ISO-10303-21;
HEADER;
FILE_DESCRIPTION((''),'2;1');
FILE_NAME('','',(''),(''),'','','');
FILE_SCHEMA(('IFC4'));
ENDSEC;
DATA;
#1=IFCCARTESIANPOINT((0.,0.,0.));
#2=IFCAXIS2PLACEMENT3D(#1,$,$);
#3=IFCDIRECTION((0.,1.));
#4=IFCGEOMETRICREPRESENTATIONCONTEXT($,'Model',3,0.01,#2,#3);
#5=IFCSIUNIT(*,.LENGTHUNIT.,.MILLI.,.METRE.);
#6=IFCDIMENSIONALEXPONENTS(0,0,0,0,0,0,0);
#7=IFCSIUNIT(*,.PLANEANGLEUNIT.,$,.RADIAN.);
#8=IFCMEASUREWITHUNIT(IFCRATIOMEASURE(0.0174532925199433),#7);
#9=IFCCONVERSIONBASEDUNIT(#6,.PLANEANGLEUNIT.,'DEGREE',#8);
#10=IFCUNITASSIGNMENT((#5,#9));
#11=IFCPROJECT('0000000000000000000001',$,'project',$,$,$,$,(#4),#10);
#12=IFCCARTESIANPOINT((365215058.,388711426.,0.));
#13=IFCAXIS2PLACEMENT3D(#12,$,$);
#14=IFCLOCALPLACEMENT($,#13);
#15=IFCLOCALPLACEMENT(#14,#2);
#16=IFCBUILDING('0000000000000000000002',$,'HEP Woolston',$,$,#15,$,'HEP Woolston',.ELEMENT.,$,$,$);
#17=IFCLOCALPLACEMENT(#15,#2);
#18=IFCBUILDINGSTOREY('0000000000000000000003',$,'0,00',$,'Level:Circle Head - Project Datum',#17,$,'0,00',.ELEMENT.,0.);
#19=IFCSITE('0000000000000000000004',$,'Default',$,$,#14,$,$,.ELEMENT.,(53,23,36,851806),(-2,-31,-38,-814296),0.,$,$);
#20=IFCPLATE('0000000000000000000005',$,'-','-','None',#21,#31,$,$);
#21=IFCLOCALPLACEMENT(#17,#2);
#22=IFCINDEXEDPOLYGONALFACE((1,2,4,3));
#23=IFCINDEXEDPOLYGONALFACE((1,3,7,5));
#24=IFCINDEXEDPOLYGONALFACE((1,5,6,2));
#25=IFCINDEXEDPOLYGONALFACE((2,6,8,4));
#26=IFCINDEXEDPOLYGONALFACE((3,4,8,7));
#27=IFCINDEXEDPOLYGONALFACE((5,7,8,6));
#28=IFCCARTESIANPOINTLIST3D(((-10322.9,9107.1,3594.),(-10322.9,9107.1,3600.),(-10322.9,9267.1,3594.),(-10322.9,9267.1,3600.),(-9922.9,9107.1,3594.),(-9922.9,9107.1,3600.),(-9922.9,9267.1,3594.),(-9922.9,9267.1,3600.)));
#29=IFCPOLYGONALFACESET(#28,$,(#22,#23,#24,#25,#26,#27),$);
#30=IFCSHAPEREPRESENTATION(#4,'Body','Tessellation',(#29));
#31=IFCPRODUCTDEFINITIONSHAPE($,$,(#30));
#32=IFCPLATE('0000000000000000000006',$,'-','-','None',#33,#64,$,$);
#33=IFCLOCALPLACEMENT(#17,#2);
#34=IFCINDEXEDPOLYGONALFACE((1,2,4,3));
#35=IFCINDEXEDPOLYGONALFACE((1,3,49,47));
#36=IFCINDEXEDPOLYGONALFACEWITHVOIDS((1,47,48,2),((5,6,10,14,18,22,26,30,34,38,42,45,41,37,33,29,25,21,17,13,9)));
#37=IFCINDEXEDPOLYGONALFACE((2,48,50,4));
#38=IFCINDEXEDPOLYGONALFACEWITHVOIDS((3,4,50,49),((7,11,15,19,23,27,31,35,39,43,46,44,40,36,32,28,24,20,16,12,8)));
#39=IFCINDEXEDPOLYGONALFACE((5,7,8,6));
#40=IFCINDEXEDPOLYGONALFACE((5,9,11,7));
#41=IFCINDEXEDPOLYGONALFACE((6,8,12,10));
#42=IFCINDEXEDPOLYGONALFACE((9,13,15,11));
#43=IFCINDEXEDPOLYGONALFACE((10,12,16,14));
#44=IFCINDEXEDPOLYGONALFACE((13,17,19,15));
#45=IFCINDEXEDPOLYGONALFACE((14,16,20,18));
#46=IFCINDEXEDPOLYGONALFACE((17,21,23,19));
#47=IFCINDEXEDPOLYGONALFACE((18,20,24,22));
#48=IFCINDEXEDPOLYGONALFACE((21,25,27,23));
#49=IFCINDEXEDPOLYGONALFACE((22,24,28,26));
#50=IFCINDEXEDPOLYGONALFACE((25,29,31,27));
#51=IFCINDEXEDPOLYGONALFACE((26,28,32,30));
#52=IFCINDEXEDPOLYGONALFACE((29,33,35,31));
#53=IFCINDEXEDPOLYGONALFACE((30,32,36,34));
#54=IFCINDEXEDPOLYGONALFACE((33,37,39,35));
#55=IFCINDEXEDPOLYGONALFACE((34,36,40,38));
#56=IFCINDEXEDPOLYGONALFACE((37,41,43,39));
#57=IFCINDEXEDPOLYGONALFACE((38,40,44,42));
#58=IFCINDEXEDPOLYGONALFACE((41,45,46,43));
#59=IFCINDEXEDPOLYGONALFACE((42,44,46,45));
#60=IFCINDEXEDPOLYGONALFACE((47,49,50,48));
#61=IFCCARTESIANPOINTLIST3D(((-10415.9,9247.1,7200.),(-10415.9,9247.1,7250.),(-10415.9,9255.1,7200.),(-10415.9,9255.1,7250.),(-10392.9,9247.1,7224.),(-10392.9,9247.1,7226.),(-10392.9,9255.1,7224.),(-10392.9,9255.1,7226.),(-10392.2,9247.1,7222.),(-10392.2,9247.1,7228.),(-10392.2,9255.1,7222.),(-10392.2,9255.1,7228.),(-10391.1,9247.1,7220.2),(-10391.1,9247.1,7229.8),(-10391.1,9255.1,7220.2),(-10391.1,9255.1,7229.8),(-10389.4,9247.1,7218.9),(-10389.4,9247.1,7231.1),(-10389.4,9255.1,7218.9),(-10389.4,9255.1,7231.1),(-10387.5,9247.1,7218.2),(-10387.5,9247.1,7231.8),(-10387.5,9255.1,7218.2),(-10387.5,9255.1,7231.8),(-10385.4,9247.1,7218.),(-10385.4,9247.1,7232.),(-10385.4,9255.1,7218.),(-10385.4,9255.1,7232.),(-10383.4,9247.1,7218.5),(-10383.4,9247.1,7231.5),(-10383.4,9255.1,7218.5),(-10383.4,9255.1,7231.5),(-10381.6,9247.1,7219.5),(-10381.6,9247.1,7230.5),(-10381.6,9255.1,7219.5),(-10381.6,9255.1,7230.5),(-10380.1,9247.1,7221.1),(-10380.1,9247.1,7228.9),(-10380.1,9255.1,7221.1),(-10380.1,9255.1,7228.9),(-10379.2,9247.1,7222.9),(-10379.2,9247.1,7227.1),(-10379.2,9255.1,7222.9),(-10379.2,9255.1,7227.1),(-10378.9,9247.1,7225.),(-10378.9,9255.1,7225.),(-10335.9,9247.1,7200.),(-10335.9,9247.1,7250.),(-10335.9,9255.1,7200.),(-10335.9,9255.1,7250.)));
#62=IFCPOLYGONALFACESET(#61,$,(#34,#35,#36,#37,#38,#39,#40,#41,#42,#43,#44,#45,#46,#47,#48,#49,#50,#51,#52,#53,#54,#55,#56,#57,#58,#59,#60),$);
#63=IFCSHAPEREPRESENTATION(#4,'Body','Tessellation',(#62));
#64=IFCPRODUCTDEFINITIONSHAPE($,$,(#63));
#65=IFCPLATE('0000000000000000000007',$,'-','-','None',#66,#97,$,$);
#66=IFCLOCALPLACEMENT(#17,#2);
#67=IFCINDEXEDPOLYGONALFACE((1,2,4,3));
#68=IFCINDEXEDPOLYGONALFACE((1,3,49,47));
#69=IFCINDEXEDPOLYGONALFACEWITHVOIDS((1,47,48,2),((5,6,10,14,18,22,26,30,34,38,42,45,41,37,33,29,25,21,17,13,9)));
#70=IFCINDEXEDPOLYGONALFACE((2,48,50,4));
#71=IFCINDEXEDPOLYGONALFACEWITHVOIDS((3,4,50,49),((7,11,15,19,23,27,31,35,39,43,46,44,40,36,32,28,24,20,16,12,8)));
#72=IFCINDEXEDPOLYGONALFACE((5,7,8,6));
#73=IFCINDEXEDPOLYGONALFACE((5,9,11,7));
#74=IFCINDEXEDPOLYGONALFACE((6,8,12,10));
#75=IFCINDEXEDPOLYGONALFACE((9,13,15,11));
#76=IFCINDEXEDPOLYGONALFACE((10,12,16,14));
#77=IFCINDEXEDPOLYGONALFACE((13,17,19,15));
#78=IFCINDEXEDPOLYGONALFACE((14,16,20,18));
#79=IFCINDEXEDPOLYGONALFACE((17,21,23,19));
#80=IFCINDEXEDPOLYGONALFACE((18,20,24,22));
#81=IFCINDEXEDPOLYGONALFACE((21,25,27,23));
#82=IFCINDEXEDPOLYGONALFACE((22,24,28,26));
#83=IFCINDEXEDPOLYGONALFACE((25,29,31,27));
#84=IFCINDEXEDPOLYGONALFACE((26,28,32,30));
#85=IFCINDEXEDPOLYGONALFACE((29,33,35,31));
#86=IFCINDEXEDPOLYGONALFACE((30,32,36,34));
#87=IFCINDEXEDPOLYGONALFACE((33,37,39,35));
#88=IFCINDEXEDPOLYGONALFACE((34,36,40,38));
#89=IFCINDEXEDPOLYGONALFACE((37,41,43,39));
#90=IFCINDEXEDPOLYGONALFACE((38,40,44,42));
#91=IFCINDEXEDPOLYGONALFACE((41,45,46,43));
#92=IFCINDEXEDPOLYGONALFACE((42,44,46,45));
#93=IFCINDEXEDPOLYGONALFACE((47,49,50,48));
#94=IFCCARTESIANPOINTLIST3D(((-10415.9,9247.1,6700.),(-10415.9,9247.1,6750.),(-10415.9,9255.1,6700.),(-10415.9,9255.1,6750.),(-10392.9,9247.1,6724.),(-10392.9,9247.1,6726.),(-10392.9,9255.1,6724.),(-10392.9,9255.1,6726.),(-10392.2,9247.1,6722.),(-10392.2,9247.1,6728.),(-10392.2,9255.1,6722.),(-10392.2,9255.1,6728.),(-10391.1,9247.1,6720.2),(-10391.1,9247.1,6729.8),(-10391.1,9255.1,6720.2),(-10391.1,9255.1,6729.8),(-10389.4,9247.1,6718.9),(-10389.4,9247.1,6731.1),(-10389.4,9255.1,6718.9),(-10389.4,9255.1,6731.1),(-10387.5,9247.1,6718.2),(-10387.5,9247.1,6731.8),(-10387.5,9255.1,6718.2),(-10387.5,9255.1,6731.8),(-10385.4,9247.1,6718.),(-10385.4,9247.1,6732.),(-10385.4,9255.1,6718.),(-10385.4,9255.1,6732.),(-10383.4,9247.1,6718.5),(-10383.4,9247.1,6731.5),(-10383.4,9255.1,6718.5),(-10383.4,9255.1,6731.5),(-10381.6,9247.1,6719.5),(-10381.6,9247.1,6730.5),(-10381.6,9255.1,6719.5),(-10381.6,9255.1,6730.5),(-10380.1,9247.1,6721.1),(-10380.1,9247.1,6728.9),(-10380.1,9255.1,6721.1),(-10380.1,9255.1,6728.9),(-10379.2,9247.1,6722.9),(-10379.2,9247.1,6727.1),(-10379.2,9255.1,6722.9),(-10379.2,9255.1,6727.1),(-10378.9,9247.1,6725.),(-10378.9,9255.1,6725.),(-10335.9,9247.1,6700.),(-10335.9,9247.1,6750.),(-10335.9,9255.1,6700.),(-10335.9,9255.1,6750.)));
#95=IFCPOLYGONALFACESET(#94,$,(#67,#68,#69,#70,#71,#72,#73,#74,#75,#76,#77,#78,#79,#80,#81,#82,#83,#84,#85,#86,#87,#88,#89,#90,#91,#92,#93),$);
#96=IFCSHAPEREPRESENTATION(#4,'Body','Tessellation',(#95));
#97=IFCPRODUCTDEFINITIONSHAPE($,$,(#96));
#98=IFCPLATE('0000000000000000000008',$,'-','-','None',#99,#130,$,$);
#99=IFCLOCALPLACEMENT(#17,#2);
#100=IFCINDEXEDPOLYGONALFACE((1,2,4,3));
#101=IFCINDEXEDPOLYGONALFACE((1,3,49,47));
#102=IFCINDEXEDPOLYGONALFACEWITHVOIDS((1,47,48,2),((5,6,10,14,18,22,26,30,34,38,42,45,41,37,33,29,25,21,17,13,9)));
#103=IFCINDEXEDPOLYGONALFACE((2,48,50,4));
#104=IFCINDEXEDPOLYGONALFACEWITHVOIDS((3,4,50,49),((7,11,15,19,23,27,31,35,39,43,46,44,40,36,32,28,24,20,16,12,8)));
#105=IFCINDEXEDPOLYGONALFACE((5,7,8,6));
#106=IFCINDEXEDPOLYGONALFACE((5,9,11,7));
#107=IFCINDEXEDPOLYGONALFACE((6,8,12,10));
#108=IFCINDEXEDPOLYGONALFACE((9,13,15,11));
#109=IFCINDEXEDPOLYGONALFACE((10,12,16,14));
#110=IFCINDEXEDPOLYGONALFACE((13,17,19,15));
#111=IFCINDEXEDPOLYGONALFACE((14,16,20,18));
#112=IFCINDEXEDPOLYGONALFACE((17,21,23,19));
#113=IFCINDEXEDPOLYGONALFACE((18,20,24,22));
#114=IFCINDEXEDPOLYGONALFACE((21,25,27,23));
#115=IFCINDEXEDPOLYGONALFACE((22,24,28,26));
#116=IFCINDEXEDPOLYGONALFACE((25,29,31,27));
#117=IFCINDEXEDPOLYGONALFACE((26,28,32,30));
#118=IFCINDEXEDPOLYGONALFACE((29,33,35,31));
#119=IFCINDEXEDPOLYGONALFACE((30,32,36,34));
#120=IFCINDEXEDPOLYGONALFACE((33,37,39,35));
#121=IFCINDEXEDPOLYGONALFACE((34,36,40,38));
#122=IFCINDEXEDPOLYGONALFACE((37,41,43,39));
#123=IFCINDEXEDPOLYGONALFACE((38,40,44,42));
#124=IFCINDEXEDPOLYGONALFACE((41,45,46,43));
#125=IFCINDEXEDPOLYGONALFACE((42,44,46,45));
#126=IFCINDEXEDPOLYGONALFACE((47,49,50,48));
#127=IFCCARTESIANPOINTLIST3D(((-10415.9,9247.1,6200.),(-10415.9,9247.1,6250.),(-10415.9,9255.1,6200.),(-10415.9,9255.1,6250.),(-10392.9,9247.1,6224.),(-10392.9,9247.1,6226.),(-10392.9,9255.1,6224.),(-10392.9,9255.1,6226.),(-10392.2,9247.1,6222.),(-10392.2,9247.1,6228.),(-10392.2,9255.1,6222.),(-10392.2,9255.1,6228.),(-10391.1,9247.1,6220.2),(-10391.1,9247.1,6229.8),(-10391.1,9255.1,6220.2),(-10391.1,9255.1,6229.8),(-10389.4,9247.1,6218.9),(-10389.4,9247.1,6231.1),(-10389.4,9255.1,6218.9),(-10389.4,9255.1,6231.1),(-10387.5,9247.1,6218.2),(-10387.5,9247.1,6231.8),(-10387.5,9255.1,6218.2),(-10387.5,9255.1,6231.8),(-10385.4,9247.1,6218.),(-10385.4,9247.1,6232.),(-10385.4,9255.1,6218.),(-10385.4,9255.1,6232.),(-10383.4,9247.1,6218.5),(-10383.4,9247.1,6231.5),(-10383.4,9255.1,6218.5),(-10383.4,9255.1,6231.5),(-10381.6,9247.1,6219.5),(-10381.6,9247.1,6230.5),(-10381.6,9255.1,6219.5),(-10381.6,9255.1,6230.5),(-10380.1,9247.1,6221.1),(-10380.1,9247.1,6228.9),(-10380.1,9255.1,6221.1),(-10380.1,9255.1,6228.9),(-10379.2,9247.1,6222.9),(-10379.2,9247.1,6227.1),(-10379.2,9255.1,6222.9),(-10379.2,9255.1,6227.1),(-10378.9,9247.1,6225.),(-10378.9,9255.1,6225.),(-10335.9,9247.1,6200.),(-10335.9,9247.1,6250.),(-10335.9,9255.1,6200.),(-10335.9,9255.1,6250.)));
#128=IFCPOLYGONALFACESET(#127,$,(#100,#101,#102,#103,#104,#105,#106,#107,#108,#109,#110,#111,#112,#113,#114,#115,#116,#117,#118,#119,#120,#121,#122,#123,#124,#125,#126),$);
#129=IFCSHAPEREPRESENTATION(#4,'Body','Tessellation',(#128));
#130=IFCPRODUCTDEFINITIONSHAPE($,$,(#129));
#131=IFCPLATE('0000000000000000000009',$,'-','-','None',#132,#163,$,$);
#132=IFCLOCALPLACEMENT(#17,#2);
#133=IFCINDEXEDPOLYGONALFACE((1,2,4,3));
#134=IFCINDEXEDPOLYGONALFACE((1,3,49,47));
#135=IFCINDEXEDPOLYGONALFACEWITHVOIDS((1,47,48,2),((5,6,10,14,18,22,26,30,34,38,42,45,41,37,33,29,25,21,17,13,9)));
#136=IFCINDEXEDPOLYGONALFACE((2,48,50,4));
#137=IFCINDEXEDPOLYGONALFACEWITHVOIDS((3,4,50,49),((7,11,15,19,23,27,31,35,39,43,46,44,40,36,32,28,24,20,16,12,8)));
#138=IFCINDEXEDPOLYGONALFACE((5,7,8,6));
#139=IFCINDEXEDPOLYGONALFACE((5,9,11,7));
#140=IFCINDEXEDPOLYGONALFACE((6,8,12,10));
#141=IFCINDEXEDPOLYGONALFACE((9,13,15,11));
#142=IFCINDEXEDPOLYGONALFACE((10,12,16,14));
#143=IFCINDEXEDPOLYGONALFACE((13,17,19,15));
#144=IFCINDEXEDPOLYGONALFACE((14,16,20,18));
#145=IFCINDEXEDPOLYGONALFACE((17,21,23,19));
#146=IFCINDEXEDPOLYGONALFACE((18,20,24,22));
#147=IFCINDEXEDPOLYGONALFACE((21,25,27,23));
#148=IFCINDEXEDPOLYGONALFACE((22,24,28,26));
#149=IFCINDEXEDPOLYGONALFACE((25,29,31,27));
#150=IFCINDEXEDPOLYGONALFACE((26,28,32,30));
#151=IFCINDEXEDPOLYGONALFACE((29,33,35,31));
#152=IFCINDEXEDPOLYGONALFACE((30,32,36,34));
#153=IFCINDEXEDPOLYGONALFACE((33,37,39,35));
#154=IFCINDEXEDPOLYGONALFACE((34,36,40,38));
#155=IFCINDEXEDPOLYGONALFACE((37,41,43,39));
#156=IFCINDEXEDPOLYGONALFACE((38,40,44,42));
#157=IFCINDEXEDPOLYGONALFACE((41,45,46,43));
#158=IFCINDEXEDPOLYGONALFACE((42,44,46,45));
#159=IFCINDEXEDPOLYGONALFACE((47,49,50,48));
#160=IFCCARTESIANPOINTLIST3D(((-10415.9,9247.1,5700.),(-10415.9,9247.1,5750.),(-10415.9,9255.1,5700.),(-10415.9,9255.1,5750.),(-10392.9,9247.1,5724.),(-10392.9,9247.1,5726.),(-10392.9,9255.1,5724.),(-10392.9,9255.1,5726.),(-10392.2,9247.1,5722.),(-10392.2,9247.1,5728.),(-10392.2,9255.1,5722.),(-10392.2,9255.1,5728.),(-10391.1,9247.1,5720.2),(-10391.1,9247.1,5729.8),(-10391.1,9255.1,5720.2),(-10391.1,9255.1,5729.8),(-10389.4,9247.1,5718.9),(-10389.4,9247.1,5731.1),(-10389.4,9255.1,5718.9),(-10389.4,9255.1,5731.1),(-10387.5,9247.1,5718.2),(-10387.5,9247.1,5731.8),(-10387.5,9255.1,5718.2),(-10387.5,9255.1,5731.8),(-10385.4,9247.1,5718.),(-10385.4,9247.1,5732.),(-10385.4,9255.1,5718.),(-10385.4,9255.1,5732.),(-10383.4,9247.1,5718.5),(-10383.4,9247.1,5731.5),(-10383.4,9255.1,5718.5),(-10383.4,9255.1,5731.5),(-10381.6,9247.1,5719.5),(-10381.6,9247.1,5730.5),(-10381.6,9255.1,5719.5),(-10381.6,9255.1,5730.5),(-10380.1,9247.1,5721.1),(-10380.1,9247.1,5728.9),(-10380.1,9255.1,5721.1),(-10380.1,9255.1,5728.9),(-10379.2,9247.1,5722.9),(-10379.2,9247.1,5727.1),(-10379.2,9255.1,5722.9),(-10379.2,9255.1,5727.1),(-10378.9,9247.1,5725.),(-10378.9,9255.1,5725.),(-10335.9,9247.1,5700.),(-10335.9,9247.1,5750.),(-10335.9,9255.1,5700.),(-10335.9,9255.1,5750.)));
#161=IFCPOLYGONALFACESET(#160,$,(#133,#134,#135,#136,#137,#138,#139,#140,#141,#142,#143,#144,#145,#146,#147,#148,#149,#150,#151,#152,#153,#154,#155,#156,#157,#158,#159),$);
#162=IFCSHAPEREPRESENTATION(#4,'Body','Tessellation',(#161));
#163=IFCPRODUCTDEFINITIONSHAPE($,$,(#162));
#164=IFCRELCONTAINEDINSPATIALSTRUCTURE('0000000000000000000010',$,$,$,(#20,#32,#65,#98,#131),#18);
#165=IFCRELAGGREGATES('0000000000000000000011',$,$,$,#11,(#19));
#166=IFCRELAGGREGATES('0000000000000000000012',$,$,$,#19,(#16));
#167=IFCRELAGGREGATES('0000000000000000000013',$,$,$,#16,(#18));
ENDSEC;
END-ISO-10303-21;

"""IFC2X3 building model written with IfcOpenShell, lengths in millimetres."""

from ifc_helpers import new_model, entity, si_unit, converted_unit, direction, frame, origin, origin_with_axes, origin_2d_with_axis, place, context, project, spatial, polyline, circle, outline, extrude, element, save


model = new_model("IFC2X3")

# Units and contexts
model_context = context("Model", 3, precision=0.01, world=origin(), true_north=direction((0.0, 1.0)))
ifc_project = project(units=[si_unit("LENGTHUNIT", "METRE", prefix="MILLI"), converted_unit("PLANEANGLEUNIT", "DEGREE", entity("IfcRatioMeasure", 0.0174532925199433), si_unit("PLANEANGLEUNIT", "RADIAN"), dimensions=[0, 0, 0, 0, 0, 0, 0])], contexts=[model_context])

# Site, building, storey
site_placement = place(None, frame((365215058.0, 388711426.0, 0.0)))
site = spatial("IfcSite", under=ifc_project, at=site_placement, Name="Default", CompositionType="ELEMENT", RefLatitude=(53, 23, 36, 851806), RefLongitude=(-2, -31, -38, -814296), RefElevation=0.0)
building_placement = place(site_placement, origin())
building = spatial("IfcBuilding", under=site, at=building_placement, Name="HEP Woolston", LongName="HEP Woolston", CompositionType="ELEMENT")
storey_placement = place(building_placement, origin())
storey = spatial("IfcBuildingStorey", under=building, at=storey_placement, Name="0,00", ObjectType="Level:Circle Head - Project Datum", LongName="0,00", CompositionType="ELEMENT", Elevation=0.0)

# Plate
plate_1_placement = place(storey_placement, frame((-10322.9, 9107.1, 3594.0)))
element("IfcPlate", 1, at=plate_1_placement, inside=storey, Name="-", Description="-", ObjectType="None", context=model_context, shape_type="SweptSolid", body=[
    extrude(outline(polyline([(0.0, 0.0), (400.0, 0.0), (400.0, 160.0), (0.0, 160.0), (0.0, 0.0)])), origin_with_axes(), (0.0, 0.0, 1.0), 6.0),
])

# Plates, openings
plate_2_placement = place(storey_placement, frame((-10335.9, 9247.1, 7250.0), z_axis=(0.0, 1.0, 0.0), x_axis=(-1.0, 0.0, 0.0)))
plate_2 = element("IfcPlate", 2, at=plate_2_placement, inside=storey, Name="-", Description="-", ObjectType="None", context=model_context, shape_type="SweptSolid", body=[
    extrude(outline(polyline([(0.0, 0.0), (0.0, -50.0), (80.0, -50.0), (80.0, 0.0), (0.0, 0.0)])), origin_with_axes(), (0.0, 0.0, 1.0), 8.0),
])
opening_1_placement = place(plate_2_placement, frame((50.0, -25.0, 8.5), z_axis=(0.0, 0.0, -1.0), x_axis=(-1.0, 0.0, 0.0)))
element("IfcOpeningElement", 3, at=opening_1_placement, cuts=plate_2, ObjectType="Opening", context=model_context, shape_type="SweptSolid", body=[
    extrude(circle(Radius=7.0, at=origin_2d_with_axis()), origin(), (0.0, 0.0, 1.0), 9.0),
])
plate_3_placement = place(storey_placement, frame((-10335.9, 9247.1, 6750.0), z_axis=(0.0, 1.0, 0.0), x_axis=(-1.0, 0.0, 0.0)))
plate_3 = element("IfcPlate", 4, at=plate_3_placement, inside=storey, Name="-", Description="-", ObjectType="None", context=model_context, shape_type="SweptSolid", body=[
    extrude(outline(polyline([(0.0, 0.0), (0.0, -50.0), (80.0, -50.0), (80.0, 0.0), (0.0, 0.0)])), origin_with_axes(), (0.0, 0.0, 1.0), 8.0),
])
opening_2_placement = place(plate_3_placement, frame((50.0, -25.0, 8.5), z_axis=(0.0, 0.0, -1.0), x_axis=(-1.0, 0.0, 0.0)))
element("IfcOpeningElement", 5, at=opening_2_placement, cuts=plate_3, ObjectType="Opening", context=model_context, shape_type="SweptSolid", body=[
    extrude(circle(Radius=7.0, at=origin_2d_with_axis()), origin(), (0.0, 0.0, 1.0), 9.0),
])
plate_4_placement = place(storey_placement, frame((-10335.9, 9247.1, 6250.0), z_axis=(0.0, 1.0, 0.0), x_axis=(-1.0, 0.0, 0.0)))
plate_4 = element("IfcPlate", 6, at=plate_4_placement, inside=storey, Name="-", Description="-", ObjectType="None", context=model_context, shape_type="SweptSolid", body=[
    extrude(outline(polyline([(0.0, 0.0), (0.0, -50.0), (80.0, -50.0), (80.0, 0.0), (0.0, 0.0)])), origin_with_axes(), (0.0, 0.0, 1.0), 8.0),
])
opening_3_placement = place(plate_4_placement, frame((50.0, -25.0, 8.5), z_axis=(0.0, 0.0, -1.0), x_axis=(-1.0, 0.0, 0.0)))
element("IfcOpeningElement", 7, at=opening_3_placement, cuts=plate_4, ObjectType="Opening", context=model_context, shape_type="SweptSolid", body=[
    extrude(circle(Radius=7.0, at=origin_2d_with_axis()), origin(), (0.0, 0.0, 1.0), 9.0),
])
plate_5_placement = place(storey_placement, frame((-10335.9, 9247.1, 5750.0), z_axis=(0.0, 1.0, 0.0), x_axis=(-1.0, 0.0, 0.0)))
plate_5 = element("IfcPlate", 8, at=plate_5_placement, inside=storey, Name="-", Description="-", ObjectType="None", context=model_context, shape_type="SweptSolid", body=[
    extrude(outline(polyline([(0.0, 0.0), (0.0, -50.0), (80.0, -50.0), (80.0, 0.0), (0.0, 0.0)])), origin_with_axes(), (0.0, 0.0, 1.0), 8.0),
])
opening_4_placement = place(plate_5_placement, frame((50.0, -25.0, 8.5), z_axis=(0.0, 0.0, -1.0), x_axis=(-1.0, 0.0, 0.0)))
element("IfcOpeningElement", 9, at=opening_4_placement, cuts=plate_5, ObjectType="Opening", context=model_context, shape_type="SweptSolid", body=[
    extrude(circle(Radius=7.0, at=origin_2d_with_axis()), origin(), (0.0, 0.0, 1.0), 9.0),
])

save(model, "model.ifc")
